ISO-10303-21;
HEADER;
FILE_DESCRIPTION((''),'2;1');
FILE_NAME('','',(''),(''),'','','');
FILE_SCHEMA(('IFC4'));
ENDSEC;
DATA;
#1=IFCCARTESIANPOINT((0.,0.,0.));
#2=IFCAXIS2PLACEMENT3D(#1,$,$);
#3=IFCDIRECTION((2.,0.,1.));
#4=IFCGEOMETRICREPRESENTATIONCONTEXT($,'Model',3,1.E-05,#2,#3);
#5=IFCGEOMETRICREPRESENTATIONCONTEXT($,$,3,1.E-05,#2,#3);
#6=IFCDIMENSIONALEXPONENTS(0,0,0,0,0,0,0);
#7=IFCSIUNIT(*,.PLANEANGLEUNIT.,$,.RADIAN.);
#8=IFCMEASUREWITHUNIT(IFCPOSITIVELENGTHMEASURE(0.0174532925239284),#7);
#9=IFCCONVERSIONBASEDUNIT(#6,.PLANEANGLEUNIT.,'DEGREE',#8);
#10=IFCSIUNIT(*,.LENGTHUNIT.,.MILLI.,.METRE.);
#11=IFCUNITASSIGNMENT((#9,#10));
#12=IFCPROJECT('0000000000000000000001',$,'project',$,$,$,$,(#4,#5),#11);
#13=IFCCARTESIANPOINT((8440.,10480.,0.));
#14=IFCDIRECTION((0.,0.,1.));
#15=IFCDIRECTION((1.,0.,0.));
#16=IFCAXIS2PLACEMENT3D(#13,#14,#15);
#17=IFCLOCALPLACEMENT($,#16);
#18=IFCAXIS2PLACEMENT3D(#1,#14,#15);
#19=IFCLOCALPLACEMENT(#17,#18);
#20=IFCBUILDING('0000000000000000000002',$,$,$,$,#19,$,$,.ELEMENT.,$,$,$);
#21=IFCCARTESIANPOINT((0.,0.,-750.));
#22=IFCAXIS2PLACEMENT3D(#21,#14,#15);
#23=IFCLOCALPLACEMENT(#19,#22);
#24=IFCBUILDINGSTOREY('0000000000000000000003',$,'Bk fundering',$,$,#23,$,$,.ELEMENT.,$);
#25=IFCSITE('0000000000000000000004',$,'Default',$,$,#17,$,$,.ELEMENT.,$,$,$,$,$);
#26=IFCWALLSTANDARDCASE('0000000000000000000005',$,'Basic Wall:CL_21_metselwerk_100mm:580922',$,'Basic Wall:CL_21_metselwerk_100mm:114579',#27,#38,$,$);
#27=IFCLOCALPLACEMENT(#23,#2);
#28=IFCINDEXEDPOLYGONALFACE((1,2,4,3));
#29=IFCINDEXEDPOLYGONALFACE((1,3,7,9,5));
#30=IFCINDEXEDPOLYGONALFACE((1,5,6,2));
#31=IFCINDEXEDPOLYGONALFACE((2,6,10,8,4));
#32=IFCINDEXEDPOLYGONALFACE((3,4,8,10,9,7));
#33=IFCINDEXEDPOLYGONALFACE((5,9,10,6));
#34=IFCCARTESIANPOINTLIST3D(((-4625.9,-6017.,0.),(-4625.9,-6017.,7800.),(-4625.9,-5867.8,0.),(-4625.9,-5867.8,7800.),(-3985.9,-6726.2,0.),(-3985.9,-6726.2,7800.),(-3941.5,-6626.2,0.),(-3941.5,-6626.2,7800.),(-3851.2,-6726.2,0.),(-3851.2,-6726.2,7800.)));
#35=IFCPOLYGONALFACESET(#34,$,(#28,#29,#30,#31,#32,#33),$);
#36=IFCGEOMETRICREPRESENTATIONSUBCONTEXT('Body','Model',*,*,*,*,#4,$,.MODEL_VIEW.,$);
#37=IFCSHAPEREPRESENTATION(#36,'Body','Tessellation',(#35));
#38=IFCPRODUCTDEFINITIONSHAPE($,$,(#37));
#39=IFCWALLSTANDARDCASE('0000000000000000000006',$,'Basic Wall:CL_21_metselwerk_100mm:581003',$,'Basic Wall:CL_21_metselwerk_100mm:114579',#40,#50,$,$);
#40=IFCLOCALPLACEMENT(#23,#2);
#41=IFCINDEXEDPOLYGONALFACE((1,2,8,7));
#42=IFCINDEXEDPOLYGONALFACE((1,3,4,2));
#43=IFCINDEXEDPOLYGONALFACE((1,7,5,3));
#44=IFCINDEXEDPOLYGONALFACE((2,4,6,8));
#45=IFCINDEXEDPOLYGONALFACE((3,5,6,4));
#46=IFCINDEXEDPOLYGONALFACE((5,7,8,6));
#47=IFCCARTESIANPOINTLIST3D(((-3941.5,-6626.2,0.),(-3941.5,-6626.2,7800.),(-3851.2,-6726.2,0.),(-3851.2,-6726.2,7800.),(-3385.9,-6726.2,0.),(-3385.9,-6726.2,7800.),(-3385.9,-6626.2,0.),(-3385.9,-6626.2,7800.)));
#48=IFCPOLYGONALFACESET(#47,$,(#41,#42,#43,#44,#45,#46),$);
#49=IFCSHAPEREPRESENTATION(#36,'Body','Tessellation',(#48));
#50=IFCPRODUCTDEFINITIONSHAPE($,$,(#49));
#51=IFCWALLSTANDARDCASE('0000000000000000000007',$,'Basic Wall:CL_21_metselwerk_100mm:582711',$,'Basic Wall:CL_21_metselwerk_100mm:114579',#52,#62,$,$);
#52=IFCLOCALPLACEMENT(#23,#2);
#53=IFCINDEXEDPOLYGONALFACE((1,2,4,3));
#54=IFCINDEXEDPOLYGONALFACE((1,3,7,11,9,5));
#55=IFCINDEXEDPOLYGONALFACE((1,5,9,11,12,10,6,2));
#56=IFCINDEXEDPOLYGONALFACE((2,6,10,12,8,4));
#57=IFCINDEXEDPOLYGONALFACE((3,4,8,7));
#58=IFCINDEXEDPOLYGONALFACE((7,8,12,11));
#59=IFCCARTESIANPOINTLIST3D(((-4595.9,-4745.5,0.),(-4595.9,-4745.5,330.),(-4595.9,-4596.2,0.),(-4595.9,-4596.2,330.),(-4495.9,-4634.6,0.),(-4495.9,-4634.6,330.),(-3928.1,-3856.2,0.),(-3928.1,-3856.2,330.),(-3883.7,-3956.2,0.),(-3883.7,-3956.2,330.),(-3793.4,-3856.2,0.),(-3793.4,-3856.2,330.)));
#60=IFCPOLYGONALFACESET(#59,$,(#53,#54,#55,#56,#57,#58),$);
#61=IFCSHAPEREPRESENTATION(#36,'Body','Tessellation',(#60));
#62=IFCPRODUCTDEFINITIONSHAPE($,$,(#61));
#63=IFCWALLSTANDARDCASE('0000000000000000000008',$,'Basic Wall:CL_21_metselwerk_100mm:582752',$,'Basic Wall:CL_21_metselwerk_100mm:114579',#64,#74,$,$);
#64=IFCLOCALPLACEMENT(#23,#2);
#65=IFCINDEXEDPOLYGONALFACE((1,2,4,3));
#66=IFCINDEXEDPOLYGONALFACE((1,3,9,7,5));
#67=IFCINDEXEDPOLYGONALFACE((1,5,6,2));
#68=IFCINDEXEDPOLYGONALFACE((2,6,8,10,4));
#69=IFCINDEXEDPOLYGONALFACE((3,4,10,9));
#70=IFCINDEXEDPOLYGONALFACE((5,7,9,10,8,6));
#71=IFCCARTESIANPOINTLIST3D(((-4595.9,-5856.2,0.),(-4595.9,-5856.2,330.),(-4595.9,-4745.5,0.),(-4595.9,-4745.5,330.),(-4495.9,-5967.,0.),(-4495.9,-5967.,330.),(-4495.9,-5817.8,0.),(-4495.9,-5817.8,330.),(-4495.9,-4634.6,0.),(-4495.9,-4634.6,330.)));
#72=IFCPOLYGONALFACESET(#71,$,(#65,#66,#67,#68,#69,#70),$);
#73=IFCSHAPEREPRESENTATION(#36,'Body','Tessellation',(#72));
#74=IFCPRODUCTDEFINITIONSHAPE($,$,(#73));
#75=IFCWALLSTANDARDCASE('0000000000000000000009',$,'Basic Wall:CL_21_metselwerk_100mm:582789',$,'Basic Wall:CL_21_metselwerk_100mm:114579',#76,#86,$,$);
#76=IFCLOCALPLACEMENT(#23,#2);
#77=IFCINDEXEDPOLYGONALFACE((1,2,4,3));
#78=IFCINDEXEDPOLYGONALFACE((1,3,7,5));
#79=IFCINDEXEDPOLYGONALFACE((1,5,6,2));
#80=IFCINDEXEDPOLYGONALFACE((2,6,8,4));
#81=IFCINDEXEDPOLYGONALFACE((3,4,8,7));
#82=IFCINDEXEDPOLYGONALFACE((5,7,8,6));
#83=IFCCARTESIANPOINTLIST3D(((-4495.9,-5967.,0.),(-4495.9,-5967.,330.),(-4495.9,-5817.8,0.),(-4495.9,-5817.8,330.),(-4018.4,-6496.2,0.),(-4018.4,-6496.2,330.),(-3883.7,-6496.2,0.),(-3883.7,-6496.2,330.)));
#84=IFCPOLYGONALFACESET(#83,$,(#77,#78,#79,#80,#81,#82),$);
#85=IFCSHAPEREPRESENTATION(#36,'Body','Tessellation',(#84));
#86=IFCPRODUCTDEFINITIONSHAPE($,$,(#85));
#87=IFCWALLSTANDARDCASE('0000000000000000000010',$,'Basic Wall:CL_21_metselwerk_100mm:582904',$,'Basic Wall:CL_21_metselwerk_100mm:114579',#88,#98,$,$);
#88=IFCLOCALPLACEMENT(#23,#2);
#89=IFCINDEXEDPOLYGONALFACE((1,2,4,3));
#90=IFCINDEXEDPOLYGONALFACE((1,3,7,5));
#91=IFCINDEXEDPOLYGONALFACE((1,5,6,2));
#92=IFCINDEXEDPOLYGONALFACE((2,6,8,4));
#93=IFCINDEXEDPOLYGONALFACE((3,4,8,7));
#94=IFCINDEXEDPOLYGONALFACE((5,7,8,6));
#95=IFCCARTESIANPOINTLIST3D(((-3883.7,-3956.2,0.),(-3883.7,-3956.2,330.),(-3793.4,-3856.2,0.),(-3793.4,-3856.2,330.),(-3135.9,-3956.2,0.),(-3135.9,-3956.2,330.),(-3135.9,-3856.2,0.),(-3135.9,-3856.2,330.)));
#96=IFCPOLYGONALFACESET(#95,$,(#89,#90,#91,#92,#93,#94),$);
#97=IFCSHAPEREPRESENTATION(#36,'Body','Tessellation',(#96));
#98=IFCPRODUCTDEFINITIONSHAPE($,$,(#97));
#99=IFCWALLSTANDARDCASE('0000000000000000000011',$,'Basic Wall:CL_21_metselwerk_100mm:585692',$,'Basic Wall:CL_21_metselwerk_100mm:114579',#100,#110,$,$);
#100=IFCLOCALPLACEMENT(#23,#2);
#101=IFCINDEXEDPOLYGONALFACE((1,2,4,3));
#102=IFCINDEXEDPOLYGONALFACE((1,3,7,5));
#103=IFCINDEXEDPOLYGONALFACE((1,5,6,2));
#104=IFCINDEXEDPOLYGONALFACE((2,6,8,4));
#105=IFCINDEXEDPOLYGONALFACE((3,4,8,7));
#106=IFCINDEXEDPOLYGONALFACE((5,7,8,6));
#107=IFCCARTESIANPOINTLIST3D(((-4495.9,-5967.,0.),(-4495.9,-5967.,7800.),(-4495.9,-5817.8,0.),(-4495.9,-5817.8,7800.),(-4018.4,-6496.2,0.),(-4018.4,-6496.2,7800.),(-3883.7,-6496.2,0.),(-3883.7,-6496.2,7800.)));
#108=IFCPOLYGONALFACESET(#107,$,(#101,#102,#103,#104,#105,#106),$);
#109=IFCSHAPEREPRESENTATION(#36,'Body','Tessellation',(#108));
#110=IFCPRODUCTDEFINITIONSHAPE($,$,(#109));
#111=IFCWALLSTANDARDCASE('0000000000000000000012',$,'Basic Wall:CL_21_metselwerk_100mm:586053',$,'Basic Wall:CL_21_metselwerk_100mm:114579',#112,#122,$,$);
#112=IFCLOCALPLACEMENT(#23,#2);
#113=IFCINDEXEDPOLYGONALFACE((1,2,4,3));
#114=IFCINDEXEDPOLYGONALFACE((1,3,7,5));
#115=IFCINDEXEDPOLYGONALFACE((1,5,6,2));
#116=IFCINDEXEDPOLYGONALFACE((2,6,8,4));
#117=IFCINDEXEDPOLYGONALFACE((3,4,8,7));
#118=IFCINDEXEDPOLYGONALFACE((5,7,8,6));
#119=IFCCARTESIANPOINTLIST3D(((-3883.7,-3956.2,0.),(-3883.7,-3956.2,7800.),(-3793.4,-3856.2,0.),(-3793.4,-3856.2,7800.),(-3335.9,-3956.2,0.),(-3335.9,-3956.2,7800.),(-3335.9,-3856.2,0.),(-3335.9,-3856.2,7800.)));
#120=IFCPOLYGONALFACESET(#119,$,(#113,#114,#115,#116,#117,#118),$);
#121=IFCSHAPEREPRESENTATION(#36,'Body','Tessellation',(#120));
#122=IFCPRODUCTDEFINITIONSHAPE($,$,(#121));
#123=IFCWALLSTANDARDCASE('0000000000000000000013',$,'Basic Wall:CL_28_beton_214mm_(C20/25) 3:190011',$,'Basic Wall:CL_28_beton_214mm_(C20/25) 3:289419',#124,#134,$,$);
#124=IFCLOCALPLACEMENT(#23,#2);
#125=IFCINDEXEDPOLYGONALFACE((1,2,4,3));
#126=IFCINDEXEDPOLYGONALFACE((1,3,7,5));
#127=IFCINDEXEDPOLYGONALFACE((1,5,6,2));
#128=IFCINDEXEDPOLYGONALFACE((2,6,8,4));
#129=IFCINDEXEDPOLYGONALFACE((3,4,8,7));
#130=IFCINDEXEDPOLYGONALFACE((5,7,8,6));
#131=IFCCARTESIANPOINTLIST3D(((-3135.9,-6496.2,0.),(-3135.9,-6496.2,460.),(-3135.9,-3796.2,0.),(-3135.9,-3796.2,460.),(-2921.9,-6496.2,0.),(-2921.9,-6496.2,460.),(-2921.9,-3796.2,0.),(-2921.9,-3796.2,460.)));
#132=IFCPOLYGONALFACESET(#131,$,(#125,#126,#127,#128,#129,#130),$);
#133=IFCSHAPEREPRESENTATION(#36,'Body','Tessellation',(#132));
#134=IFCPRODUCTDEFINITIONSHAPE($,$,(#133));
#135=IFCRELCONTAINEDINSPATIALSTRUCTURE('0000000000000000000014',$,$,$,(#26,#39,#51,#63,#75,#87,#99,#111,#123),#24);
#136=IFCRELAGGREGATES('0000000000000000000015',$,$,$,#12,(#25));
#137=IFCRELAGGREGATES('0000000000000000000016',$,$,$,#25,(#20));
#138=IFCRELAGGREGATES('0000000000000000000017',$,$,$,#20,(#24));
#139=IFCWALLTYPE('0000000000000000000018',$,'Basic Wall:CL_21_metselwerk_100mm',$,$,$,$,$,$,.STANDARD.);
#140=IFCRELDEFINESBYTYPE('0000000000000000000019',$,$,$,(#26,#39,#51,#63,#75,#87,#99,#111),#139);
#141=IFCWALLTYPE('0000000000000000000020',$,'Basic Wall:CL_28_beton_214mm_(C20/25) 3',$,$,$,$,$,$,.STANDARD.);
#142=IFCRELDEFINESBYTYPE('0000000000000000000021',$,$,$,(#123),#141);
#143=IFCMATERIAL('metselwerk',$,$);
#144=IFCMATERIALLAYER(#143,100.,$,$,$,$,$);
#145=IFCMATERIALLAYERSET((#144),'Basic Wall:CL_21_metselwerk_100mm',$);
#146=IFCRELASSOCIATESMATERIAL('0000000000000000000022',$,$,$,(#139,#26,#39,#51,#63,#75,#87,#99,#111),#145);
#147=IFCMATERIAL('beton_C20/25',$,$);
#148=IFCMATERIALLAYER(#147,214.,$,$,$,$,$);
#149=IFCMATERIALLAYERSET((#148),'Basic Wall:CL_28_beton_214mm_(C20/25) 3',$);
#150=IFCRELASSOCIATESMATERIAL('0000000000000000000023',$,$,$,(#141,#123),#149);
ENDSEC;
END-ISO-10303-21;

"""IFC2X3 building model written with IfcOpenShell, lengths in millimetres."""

from ifc_helpers import new_model, entity, si_unit, converted_unit, direction, frame, frame_2d, origin, origin_with_axes, place, context, subcontext, project, spatial, polyline, rectangle, outline, extrude, clip, bounded_halfspace, material, layer, layer_set, layer_usage, type_object, element, save


model = new_model("IFC2X3")

# Units and contexts
model_context = context("Model", 3, precision=1e-05, world=origin(), true_north=direction((2.0, 0.0, 1.0)))
context_of_model = context(None, 3, precision=1e-05, world=origin(), true_north=direction((2.0, 0.0, 1.0)))
body_context = subcontext(model_context, "Body", "Model", "MODEL_VIEW")
ifc_project = project(units=[converted_unit("PLANEANGLEUNIT", "DEGREE", entity("IfcPositiveLengthMeasure", 0.0174532925239284), si_unit("PLANEANGLEUNIT", "RADIAN"), dimensions=[0, 0, 0, 0, 0, 0, 0]), si_unit("LENGTHUNIT", "METRE", prefix="MILLI")], contexts=[model_context, context_of_model])

# Site, building, storey
site_placement = place(None, frame((8440.0, 10480.0, 0.0), z_axis=(0.0, 0.0, 1.0), x_axis=(1.0, 0.0, 0.0)))
site = spatial("IfcSite", under=ifc_project, at=site_placement, Name="Default", CompositionType="ELEMENT")
building_placement = place(site_placement, origin_with_axes())
building = spatial("IfcBuilding", under=site, at=building_placement, CompositionType="ELEMENT")
storey_placement = place(building_placement, frame((0.0, 0.0, -750.0), z_axis=(0.0, 0.0, 1.0), x_axis=(1.0, 0.0, 0.0)))
storey = spatial("IfcBuildingStorey", under=building, at=storey_placement, Name="Bk fundering", CompositionType="ELEMENT")

# Walls
ifc_material_1 = material(Name="metselwerk")
ifc_layer_1 = layer(ifc_material_1, 100.0)
ifc_layer_set_1 = layer_set([ifc_layer_1], Name="Basic Wall:CL_21_metselwerk_100mm")
wall_type_1 = type_object("IfcWallType", Name="Basic Wall:CL_21_metselwerk_100mm", PredefinedType="STANDARD", material=ifc_layer_set_1)
ifc_layer_usage_1 = layer_usage(ifc_layer_set_1, "AXIS2", "NEGATIVE", 50.0)
wall_1_placement = place(storey_placement, frame((-4663.0, -5901.2, 0.0), z_axis=(0.0, 0.0, 1.0), x_axis=(0.669965, -0.742393, 0.0)))
element("IfcWallStandardCase", 1, at=wall_1_placement, inside=storey, type_object=wall_type_1, material=ifc_layer_usage_1, Name="Basic Wall:CL_21_metselwerk_100mm:580922", ObjectType="Basic Wall:CL_21_metselwerk_100mm:114579", context=body_context, shape_type="SweptSolid", body=[
    extrude(outline(polyline([(1066.1, -50.0), (1156.3, 50.0), (1021.6, 50.0), (0.0, 50.0), (110.8, -50.0), (1066.1, -50.0)])), origin(), (0.0, 0.0, 1.0), 7800.0),
])
ifc_layer_usage_2 = layer_usage(ifc_layer_set_1, "AXIS2", "POSITIVE", -50.0)
wall_2_placement = place(storey_placement, frame((-3941.5, -6676.2, 0.0), z_axis=(0.0, 0.0, 1.0), x_axis=(1.0, 0.0, 0.0)))
element("IfcWallStandardCase", 2, at=wall_2_placement, inside=storey, type_object=wall_type_1, material=ifc_layer_usage_2, Name="Basic Wall:CL_21_metselwerk_100mm:581003", ObjectType="Basic Wall:CL_21_metselwerk_100mm:114579", context=body_context, shape_type="SweptSolid", body=[
    extrude(outline(polyline([(555.6, -50.0), (555.6, 50.0), (0.0, 50.0), (90.2, -50.0), (555.6, -50.0)])), origin(), (0.0, 0.0, 1.0), 7800.0),
])
ifc_layer_usage_3 = layer_usage(ifc_layer_set_1, "AXIS2", "NEGATIVE", 50.0)
wall_3_placement = place(storey_placement, frame((-3830.5, -3822.7, 0.0), z_axis=(0.0, 0.0, 1.0), x_axis=(-0.669965, -0.742393, 0.0)))
element("IfcWallStandardCase", 3, at=wall_3_placement, inside=storey, type_object=wall_type_1, material=ifc_layer_usage_3, Name="Basic Wall:CL_21_metselwerk_100mm:582711", ObjectType="Basic Wall:CL_21_metselwerk_100mm:114579", context=body_context, shape_type="SweptSolid", body=[
    extrude(outline(polyline([(1087.0, -50.0), (1197.8, 50.0), (1048.6, 50.0), (134.7, 50.0), (0.0, 50.0), (90.2, -50.0), (1087.0, -50.0)])), origin(), (0.0, 0.0, 1.0), 330.0),
])
ifc_layer_usage_4 = layer_usage(ifc_layer_set_1, "AXIS2", "NEGATIVE", 50.0)
wall_4_placement = place(storey_placement, frame((-4545.9, -4634.6, 0.0), z_axis=(0.0, 0.0, 1.0), x_axis=(0.0, -1.0, 0.0)))
element("IfcWallStandardCase", 4, at=wall_4_placement, inside=storey, type_object=wall_type_1, material=ifc_layer_usage_4, Name="Basic Wall:CL_21_metselwerk_100mm:582752", ObjectType="Basic Wall:CL_21_metselwerk_100mm:114579", context=body_context, shape_type="SweptSolid", body=[
    extrude(outline(polyline([(1221.6, -50.0), (1332.4, 50.0), (1183.1, 50.0), (0.0, 50.0), (110.8, -50.0), (1221.6, -50.0)])), origin(), (0.0, 0.0, 1.0), 330.0),
])
ifc_layer_usage_5 = layer_usage(ifc_layer_set_1, "AXIS2", "NEGATIVE", 50.0)
wall_5_placement = place(storey_placement, frame((-4533.0, -5851.3, 0.0), z_axis=(0.0, 0.0, 1.0), x_axis=(0.669965, -0.742393, 0.0)))
element("IfcWallStandardCase", 5, at=wall_5_placement, inside=storey, type_object=wall_type_1, material=ifc_layer_usage_5, Name="Basic Wall:CL_21_metselwerk_100mm:582789", ObjectType="Basic Wall:CL_21_metselwerk_100mm:114579", context=body_context, shape_type="SweptSolid", body=[
    extrude(outline(polyline([(823.6, -50.0), (913.9, 50.0), (0.0, 50.0), (110.8, -50.0), (823.6, -50.0)])), origin(), (0.0, 0.0, 1.0), 330.0),
])
ifc_layer_usage_6 = layer_usage(ifc_layer_set_1, "AXIS2", "NEGATIVE", 50.0)
wall_6_placement = place(storey_placement, frame((-3135.9, -3906.2, 0.0), z_axis=(0.0, 0.0, 1.0), x_axis=(-1.0, 0.0, 0.0)))
element("IfcWallStandardCase", 6, at=wall_6_placement, inside=storey, type_object=wall_type_1, material=ifc_layer_usage_6, Name="Basic Wall:CL_21_metselwerk_100mm:582904", ObjectType="Basic Wall:CL_21_metselwerk_100mm:114579", context=body_context, shape_type="SweptSolid", body=[
    extrude(outline(polyline([(657.5, -50.0), (747.8, 50.0), (0.0, 50.0), (0.0, -50.0), (657.5, -50.0)])), origin(), (0.0, 0.0, 1.0), 330.0),
])

# Wall
ifc_layer_usage_7 = layer_usage(ifc_layer_set_1, "AXIS2", "NEGATIVE", 50.0)
wall_7_placement = place(storey_placement, frame((-4533.0, -5851.3, 0.0), z_axis=(0.0, 0.0, 1.0), x_axis=(0.669965, -0.742393, 0.0)))
element("IfcWallStandardCase", 7, at=wall_7_placement, inside=storey, type_object=wall_type_1, material=ifc_layer_usage_7, Name="Basic Wall:CL_21_metselwerk_100mm:585692", ObjectType="Basic Wall:CL_21_metselwerk_100mm:114579", context=body_context, shape_type="SweptSolid", body=[
    extrude(outline(polyline([(823.6, -50.0), (913.9, 50.0), (0.0, 50.0), (110.8, -50.0), (823.6, -50.0)])), origin(), (0.0, 0.0, 1.0), 7800.0),
])

# Walls
ifc_layer_usage_8 = layer_usage(ifc_layer_set_1, "AXIS2", "NEGATIVE", 50.0)
wall_8_placement = place(storey_placement, frame((-3335.9, -3906.2, 0.0), z_axis=(0.0, 0.0, 1.0), x_axis=(-1.0, 0.0, 0.0)))
element("IfcWallStandardCase", 8, at=wall_8_placement, inside=storey, type_object=wall_type_1, material=ifc_layer_usage_8, Name="Basic Wall:CL_21_metselwerk_100mm:586053", ObjectType="Basic Wall:CL_21_metselwerk_100mm:114579", context=body_context, shape_type="SweptSolid", body=[
    extrude(outline(polyline([(457.5, -50.0), (547.8, 50.0), (0.0, 50.0), (0.0, -50.0), (457.5, -50.0)])), origin(), (0.0, 0.0, 1.0), 7800.0),
])
ifc_material_2 = material(Name="beton_C20/25")
ifc_layer_2 = layer(ifc_material_2, 214.0)
ifc_layer_set_2 = layer_set([ifc_layer_2], Name="Basic Wall:CL_28_beton_214mm_(C20/25) 3")
ifc_layer_usage_9 = layer_usage(ifc_layer_set_2, "AXIS2", "NEGATIVE", 107.0)
wall_type_2 = type_object("IfcWallType", Name="Basic Wall:CL_28_beton_214mm_(C20/25) 3", PredefinedType="STANDARD", material=ifc_layer_set_2)
wall_9_placement = place(storey_placement, frame((-3028.9, -3796.2, 0.0), z_axis=(0.0, 0.0, 1.0), x_axis=(0.0, -1.0, 0.0)))
element("IfcWallStandardCase", 9, at=wall_9_placement, inside=storey, type_object=wall_type_2, material=ifc_layer_usage_9, Name="Basic Wall:CL_28_beton_214mm_(C20/25) 3:190011", ObjectType="Basic Wall:CL_28_beton_214mm_(C20/25) 3:289419", context=body_context, shape_type="Clipping", body=[
    clip(extrude(rectangle(XDim=2700.0, YDim=214.0, at=frame_2d((1350.0, 0.0), x_axis=(-1.0, 0.0))), origin(), (0.0, 0.0, 1.0), 460.0), bounded_halfspace(frame((0.0, -107.0, 460.0), z_axis=(0.0, 0.0, -1.0), x_axis=(1.0, 0.0, 0.0)), True, frame((0.0, -107.0, 460.0)), polyline([(0.0, 0.0), (60.0, 0.0), (2700.0, 0.0), (2700.0, 214.0), (0.0, 214.0), (0.0, 0.0)]))),
])

save(model, "model.ifc")
